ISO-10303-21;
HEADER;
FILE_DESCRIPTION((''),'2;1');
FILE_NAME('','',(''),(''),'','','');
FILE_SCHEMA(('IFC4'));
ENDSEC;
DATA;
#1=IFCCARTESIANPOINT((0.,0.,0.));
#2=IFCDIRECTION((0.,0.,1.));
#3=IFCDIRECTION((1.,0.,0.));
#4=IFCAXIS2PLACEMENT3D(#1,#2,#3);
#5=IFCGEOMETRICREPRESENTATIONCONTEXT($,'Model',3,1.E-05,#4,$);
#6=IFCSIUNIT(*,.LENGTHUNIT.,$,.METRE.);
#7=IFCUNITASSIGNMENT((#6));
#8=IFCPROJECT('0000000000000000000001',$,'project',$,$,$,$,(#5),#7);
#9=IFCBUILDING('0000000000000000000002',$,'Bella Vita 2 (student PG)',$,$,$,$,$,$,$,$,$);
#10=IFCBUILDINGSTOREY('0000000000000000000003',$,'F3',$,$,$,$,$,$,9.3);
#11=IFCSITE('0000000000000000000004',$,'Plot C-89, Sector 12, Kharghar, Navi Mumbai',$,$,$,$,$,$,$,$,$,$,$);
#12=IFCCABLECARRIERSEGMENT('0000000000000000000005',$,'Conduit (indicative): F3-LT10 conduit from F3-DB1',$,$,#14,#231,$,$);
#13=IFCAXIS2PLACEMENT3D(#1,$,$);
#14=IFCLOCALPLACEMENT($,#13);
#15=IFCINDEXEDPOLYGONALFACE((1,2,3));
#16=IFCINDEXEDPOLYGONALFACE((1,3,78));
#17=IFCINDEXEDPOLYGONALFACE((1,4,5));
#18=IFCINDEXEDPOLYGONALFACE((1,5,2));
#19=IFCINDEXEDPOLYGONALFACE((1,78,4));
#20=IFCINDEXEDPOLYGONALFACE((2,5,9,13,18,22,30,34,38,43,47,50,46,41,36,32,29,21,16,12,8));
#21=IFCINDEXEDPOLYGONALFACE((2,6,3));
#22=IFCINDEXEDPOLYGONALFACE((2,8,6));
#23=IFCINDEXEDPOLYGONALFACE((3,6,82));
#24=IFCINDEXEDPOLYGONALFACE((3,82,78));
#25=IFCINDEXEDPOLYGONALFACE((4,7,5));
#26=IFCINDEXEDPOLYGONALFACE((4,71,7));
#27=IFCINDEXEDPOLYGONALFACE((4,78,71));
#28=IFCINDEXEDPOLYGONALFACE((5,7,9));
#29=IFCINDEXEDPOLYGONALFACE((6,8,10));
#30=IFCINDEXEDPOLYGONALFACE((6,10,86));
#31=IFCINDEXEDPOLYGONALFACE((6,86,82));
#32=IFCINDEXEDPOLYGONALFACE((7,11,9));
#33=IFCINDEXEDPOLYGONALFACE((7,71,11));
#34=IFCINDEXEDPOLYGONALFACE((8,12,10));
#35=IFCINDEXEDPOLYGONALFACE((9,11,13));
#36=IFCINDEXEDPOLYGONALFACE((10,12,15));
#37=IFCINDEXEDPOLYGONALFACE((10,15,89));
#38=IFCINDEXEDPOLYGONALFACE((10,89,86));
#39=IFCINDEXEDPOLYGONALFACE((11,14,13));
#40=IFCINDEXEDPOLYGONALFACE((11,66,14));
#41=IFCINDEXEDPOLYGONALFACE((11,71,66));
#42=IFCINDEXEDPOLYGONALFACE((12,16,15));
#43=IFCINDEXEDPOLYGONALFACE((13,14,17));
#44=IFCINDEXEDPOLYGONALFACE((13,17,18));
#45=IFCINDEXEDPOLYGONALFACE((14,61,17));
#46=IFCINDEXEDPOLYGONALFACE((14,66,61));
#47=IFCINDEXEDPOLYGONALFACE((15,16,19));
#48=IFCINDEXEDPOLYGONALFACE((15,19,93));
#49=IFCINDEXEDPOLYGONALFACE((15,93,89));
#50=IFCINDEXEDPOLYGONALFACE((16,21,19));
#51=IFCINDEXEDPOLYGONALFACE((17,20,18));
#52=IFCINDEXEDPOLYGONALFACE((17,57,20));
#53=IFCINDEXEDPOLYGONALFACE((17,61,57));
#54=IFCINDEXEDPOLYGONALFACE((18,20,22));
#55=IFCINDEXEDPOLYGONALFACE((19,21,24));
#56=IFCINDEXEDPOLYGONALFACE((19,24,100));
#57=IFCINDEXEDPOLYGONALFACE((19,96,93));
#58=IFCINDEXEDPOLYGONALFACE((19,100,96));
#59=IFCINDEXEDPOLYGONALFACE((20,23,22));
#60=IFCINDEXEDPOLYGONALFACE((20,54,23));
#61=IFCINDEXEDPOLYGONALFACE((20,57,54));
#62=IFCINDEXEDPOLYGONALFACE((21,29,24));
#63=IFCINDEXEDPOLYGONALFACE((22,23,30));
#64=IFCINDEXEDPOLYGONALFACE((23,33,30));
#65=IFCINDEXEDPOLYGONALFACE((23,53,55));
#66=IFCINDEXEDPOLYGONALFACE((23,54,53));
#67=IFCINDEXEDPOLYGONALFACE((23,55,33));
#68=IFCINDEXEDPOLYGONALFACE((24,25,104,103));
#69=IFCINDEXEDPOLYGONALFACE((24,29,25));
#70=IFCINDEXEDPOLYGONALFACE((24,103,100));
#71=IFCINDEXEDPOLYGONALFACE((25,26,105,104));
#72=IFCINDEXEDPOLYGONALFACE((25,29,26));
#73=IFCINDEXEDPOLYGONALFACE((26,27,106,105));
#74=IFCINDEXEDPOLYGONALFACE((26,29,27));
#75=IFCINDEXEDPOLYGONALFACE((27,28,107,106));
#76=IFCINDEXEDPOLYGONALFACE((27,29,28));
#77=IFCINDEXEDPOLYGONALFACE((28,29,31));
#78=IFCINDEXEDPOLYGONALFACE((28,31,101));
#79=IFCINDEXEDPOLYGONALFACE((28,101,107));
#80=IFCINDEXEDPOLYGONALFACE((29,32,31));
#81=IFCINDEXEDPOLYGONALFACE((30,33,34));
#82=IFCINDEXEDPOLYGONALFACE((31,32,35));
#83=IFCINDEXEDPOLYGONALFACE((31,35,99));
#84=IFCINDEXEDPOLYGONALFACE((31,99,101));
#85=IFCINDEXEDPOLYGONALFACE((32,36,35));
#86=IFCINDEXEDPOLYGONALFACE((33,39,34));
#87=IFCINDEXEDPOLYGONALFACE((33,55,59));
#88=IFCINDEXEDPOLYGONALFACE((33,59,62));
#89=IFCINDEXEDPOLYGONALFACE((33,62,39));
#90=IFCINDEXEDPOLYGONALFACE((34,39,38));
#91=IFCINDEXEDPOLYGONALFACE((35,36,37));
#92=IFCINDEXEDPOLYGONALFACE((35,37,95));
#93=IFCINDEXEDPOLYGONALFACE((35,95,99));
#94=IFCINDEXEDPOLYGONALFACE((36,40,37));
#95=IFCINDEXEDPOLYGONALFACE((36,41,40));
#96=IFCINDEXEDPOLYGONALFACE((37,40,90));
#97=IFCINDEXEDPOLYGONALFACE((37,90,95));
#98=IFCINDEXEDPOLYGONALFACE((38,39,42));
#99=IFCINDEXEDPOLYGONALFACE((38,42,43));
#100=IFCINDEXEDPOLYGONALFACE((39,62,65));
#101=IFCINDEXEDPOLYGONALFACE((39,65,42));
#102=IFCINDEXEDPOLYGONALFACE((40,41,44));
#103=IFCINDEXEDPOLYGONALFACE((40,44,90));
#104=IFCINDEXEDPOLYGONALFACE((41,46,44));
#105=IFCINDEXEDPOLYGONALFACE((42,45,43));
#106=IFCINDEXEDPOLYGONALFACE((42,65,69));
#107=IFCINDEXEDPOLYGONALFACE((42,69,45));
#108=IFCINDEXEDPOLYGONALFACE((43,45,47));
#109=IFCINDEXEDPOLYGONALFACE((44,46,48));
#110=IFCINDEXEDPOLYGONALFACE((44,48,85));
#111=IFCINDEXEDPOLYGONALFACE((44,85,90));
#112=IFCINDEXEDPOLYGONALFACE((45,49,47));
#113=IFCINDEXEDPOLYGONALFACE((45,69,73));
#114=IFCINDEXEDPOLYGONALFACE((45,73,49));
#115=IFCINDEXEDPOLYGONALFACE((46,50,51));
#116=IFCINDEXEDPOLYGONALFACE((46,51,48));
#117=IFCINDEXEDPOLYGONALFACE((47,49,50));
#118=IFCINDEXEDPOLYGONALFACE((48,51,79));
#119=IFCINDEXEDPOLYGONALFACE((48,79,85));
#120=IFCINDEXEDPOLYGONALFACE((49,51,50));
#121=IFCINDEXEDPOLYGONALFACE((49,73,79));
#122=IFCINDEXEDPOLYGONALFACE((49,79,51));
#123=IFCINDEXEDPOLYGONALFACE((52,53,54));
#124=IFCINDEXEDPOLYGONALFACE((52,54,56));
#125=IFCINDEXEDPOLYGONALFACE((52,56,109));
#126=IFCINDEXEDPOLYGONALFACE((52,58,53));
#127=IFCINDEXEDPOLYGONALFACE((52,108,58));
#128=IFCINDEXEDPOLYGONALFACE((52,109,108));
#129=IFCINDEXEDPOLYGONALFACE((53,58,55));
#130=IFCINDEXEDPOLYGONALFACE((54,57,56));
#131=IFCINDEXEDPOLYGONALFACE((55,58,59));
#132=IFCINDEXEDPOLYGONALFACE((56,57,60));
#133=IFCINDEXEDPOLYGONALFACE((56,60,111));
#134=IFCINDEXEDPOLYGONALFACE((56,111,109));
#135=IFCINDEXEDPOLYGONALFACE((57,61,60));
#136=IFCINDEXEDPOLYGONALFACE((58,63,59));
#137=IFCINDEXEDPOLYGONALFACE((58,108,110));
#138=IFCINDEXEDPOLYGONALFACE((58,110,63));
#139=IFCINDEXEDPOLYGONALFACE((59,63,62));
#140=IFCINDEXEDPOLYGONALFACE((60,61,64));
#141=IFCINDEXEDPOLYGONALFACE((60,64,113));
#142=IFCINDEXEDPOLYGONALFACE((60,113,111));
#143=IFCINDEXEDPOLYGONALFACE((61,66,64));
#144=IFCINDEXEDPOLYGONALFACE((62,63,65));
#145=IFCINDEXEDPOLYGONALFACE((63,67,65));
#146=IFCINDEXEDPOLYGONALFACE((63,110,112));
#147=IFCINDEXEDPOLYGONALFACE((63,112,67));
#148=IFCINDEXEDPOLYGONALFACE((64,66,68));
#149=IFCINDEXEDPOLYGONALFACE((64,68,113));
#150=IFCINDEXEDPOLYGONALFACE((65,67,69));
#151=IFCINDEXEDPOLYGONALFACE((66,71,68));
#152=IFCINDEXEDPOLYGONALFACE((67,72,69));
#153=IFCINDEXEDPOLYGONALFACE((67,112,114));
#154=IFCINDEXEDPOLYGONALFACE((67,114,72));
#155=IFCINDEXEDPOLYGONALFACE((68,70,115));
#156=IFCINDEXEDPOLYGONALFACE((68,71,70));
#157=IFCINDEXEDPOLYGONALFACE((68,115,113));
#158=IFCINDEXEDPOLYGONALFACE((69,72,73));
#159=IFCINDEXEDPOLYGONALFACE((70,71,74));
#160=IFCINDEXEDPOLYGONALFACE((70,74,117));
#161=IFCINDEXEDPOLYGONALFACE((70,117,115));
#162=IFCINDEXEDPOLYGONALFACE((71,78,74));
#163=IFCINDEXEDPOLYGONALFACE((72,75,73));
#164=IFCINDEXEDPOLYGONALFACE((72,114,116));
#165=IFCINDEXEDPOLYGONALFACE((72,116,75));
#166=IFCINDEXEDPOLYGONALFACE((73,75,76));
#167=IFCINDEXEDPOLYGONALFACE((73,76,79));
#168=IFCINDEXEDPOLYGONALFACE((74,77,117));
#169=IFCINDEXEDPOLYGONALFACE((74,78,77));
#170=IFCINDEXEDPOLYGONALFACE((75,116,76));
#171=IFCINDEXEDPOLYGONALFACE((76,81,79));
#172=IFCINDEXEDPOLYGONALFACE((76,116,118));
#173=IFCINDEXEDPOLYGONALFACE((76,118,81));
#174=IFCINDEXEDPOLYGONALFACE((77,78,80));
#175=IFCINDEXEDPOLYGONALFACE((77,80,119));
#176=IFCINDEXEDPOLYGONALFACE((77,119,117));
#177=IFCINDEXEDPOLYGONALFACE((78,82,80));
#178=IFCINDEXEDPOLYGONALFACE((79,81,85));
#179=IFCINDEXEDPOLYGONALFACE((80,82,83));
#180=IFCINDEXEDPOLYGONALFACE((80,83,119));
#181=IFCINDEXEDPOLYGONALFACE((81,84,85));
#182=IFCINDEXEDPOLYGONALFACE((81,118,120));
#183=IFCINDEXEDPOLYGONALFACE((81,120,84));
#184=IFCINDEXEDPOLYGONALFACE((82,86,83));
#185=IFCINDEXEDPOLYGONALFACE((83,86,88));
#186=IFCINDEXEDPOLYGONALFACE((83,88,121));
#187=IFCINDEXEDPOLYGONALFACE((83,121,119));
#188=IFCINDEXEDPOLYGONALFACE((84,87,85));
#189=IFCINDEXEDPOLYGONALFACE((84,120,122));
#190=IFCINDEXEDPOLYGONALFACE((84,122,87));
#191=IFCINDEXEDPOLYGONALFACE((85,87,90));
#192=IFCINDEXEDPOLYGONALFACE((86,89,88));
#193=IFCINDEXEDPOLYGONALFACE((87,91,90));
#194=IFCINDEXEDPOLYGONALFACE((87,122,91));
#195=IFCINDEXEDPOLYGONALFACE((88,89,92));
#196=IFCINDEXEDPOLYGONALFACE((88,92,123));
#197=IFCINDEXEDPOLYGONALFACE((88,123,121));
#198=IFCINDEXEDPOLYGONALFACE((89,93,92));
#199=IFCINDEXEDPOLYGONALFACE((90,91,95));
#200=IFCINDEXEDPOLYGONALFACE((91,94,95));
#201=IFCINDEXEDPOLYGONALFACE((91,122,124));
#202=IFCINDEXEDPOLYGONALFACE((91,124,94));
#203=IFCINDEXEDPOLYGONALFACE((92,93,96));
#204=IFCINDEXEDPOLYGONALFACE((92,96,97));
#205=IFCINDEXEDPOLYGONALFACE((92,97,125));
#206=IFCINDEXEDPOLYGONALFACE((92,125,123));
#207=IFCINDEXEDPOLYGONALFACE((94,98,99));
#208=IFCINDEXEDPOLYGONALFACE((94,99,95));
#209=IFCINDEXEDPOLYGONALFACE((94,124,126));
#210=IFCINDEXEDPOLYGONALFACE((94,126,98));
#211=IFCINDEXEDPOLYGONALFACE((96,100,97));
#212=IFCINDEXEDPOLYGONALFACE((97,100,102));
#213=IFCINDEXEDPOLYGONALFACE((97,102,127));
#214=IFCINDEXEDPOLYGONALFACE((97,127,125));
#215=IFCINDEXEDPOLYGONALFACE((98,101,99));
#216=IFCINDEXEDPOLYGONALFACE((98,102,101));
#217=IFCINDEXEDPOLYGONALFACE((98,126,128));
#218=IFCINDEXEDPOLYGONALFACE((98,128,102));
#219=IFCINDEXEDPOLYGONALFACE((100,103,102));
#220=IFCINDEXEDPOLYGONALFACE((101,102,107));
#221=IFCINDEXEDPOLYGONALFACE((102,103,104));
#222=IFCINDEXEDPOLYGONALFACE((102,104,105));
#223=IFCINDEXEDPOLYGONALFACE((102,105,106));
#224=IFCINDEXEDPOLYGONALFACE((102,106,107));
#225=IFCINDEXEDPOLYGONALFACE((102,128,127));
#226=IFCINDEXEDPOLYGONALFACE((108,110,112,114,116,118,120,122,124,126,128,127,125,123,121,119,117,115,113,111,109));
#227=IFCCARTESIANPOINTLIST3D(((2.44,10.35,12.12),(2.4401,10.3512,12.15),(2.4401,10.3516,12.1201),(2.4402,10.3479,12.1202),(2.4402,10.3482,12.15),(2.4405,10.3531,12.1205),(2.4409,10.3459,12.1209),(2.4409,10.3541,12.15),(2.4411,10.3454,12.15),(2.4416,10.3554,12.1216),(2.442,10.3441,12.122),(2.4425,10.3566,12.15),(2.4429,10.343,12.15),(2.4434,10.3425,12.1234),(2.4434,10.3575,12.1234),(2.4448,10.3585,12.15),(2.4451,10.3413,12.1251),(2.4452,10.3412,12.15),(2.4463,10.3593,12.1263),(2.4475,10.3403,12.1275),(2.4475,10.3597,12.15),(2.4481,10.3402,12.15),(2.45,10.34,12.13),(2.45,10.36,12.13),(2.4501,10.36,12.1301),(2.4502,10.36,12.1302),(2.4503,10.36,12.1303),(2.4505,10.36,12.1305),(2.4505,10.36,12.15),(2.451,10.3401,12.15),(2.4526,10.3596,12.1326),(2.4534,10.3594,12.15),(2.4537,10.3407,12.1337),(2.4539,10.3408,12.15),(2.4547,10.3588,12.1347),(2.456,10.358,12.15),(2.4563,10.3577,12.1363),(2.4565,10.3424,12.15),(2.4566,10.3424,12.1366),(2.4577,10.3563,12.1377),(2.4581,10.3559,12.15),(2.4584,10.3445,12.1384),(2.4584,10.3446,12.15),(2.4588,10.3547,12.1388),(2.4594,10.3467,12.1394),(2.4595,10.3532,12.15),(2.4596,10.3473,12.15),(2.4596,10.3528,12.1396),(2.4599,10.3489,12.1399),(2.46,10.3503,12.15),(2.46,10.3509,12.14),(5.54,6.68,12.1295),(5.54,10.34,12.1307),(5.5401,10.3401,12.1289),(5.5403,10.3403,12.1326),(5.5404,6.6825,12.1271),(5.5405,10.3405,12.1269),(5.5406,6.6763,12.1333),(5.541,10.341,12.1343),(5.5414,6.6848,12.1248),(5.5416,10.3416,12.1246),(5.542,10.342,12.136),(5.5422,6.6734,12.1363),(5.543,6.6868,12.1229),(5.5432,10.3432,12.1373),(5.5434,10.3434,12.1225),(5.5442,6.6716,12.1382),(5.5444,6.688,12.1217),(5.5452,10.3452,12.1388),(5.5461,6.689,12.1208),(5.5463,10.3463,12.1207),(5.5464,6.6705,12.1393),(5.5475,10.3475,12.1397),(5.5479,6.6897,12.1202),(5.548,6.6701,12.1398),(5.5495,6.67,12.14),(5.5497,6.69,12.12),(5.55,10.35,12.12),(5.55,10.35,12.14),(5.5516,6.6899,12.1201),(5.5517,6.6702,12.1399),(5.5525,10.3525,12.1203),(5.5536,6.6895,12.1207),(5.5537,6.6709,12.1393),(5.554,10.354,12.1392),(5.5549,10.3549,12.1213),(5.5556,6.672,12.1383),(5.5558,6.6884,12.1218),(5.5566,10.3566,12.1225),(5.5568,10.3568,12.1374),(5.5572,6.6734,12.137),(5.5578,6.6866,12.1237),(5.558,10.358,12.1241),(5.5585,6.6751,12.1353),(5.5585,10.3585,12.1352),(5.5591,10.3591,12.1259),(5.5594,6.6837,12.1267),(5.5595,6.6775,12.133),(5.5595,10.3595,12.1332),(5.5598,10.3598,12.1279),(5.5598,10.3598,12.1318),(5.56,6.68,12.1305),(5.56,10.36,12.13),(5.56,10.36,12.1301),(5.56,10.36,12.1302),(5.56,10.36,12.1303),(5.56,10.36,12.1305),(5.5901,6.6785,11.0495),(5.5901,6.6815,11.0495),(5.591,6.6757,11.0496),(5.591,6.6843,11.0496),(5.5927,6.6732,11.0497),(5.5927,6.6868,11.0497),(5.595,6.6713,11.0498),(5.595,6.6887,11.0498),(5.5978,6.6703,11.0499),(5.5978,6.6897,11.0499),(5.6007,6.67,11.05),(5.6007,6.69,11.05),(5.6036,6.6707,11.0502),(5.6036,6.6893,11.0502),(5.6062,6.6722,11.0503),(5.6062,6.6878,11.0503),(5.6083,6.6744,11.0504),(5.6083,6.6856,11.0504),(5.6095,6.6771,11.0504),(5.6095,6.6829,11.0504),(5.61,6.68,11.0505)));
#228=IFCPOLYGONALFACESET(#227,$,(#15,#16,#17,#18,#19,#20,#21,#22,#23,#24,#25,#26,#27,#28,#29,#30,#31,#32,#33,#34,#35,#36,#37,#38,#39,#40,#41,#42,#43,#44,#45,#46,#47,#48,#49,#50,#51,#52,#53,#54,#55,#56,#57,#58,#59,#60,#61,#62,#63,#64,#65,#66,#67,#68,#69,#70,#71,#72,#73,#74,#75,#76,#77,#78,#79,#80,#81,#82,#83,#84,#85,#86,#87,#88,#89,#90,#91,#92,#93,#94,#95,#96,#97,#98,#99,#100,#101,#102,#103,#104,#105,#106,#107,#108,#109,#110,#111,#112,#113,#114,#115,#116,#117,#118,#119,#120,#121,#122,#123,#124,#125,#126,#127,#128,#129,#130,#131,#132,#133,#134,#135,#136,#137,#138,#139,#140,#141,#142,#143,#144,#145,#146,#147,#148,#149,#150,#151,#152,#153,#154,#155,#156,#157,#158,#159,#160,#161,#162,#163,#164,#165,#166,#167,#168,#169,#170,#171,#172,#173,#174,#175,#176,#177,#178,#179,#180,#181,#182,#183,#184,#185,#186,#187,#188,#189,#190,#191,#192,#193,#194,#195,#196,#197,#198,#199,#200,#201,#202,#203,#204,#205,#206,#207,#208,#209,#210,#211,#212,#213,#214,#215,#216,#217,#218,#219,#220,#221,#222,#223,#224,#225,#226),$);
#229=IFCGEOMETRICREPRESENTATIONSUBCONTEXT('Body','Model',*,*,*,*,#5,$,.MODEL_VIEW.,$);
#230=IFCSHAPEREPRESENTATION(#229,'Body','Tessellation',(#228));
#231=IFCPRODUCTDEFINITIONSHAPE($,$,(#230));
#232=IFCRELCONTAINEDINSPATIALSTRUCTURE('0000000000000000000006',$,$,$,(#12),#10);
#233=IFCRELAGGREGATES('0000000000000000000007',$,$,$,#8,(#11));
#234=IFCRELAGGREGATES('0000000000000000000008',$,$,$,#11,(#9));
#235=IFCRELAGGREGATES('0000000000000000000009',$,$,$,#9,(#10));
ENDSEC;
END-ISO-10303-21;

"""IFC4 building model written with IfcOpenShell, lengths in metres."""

from ifc_helpers import new_model, entity, si_unit, origin, origin_with_axes, place, context, subcontext, project, spatial, element, save


model = new_model("IFC4")

# Units and contexts
model_context = context("Model", 3, precision=1e-05, world=origin_with_axes())
body_context = subcontext(model_context, "Body", "Model", "MODEL_VIEW")
ifc_project = project(units=[si_unit("LENGTHUNIT", "METRE")], contexts=[model_context])

# Site, building, storey
site = spatial("IfcSite", under=ifc_project, Name="Plot C-89, Sector 12, Kharghar, Navi Mumbai")
building = spatial("IfcBuilding", under=site, Name="Bella Vita 2 (student PG)")
storey = spatial("IfcBuildingStorey", under=building, Name="F3", Elevation=9.3)

# Cable carrier segment
cable_carrier_segment_1_placement = place(None, origin())
element("IfcCableCarrierSegment", 1, at=cable_carrier_segment_1_placement, inside=storey, Name="Conduit (indicative): F3-LT10 conduit from F3-DB1", context=body_context, shape_type="AdvancedSweptSolid", body=[
    entity("IfcSweptDiskSolid", entity("IfcPolyline", [entity("IfcCartesianPoint", [5.6, 6.68, 11.05]), entity("IfcCartesianPoint", [5.55, 6.68, 12.13]), entity("IfcCartesianPoint", [5.55, 10.35, 12.13]), entity("IfcCartesianPoint", [2.45, 10.35, 12.13]), entity("IfcCartesianPoint", [2.45, 10.35, 12.15])]), 0.01),
])

save(model, "model.ifc")
